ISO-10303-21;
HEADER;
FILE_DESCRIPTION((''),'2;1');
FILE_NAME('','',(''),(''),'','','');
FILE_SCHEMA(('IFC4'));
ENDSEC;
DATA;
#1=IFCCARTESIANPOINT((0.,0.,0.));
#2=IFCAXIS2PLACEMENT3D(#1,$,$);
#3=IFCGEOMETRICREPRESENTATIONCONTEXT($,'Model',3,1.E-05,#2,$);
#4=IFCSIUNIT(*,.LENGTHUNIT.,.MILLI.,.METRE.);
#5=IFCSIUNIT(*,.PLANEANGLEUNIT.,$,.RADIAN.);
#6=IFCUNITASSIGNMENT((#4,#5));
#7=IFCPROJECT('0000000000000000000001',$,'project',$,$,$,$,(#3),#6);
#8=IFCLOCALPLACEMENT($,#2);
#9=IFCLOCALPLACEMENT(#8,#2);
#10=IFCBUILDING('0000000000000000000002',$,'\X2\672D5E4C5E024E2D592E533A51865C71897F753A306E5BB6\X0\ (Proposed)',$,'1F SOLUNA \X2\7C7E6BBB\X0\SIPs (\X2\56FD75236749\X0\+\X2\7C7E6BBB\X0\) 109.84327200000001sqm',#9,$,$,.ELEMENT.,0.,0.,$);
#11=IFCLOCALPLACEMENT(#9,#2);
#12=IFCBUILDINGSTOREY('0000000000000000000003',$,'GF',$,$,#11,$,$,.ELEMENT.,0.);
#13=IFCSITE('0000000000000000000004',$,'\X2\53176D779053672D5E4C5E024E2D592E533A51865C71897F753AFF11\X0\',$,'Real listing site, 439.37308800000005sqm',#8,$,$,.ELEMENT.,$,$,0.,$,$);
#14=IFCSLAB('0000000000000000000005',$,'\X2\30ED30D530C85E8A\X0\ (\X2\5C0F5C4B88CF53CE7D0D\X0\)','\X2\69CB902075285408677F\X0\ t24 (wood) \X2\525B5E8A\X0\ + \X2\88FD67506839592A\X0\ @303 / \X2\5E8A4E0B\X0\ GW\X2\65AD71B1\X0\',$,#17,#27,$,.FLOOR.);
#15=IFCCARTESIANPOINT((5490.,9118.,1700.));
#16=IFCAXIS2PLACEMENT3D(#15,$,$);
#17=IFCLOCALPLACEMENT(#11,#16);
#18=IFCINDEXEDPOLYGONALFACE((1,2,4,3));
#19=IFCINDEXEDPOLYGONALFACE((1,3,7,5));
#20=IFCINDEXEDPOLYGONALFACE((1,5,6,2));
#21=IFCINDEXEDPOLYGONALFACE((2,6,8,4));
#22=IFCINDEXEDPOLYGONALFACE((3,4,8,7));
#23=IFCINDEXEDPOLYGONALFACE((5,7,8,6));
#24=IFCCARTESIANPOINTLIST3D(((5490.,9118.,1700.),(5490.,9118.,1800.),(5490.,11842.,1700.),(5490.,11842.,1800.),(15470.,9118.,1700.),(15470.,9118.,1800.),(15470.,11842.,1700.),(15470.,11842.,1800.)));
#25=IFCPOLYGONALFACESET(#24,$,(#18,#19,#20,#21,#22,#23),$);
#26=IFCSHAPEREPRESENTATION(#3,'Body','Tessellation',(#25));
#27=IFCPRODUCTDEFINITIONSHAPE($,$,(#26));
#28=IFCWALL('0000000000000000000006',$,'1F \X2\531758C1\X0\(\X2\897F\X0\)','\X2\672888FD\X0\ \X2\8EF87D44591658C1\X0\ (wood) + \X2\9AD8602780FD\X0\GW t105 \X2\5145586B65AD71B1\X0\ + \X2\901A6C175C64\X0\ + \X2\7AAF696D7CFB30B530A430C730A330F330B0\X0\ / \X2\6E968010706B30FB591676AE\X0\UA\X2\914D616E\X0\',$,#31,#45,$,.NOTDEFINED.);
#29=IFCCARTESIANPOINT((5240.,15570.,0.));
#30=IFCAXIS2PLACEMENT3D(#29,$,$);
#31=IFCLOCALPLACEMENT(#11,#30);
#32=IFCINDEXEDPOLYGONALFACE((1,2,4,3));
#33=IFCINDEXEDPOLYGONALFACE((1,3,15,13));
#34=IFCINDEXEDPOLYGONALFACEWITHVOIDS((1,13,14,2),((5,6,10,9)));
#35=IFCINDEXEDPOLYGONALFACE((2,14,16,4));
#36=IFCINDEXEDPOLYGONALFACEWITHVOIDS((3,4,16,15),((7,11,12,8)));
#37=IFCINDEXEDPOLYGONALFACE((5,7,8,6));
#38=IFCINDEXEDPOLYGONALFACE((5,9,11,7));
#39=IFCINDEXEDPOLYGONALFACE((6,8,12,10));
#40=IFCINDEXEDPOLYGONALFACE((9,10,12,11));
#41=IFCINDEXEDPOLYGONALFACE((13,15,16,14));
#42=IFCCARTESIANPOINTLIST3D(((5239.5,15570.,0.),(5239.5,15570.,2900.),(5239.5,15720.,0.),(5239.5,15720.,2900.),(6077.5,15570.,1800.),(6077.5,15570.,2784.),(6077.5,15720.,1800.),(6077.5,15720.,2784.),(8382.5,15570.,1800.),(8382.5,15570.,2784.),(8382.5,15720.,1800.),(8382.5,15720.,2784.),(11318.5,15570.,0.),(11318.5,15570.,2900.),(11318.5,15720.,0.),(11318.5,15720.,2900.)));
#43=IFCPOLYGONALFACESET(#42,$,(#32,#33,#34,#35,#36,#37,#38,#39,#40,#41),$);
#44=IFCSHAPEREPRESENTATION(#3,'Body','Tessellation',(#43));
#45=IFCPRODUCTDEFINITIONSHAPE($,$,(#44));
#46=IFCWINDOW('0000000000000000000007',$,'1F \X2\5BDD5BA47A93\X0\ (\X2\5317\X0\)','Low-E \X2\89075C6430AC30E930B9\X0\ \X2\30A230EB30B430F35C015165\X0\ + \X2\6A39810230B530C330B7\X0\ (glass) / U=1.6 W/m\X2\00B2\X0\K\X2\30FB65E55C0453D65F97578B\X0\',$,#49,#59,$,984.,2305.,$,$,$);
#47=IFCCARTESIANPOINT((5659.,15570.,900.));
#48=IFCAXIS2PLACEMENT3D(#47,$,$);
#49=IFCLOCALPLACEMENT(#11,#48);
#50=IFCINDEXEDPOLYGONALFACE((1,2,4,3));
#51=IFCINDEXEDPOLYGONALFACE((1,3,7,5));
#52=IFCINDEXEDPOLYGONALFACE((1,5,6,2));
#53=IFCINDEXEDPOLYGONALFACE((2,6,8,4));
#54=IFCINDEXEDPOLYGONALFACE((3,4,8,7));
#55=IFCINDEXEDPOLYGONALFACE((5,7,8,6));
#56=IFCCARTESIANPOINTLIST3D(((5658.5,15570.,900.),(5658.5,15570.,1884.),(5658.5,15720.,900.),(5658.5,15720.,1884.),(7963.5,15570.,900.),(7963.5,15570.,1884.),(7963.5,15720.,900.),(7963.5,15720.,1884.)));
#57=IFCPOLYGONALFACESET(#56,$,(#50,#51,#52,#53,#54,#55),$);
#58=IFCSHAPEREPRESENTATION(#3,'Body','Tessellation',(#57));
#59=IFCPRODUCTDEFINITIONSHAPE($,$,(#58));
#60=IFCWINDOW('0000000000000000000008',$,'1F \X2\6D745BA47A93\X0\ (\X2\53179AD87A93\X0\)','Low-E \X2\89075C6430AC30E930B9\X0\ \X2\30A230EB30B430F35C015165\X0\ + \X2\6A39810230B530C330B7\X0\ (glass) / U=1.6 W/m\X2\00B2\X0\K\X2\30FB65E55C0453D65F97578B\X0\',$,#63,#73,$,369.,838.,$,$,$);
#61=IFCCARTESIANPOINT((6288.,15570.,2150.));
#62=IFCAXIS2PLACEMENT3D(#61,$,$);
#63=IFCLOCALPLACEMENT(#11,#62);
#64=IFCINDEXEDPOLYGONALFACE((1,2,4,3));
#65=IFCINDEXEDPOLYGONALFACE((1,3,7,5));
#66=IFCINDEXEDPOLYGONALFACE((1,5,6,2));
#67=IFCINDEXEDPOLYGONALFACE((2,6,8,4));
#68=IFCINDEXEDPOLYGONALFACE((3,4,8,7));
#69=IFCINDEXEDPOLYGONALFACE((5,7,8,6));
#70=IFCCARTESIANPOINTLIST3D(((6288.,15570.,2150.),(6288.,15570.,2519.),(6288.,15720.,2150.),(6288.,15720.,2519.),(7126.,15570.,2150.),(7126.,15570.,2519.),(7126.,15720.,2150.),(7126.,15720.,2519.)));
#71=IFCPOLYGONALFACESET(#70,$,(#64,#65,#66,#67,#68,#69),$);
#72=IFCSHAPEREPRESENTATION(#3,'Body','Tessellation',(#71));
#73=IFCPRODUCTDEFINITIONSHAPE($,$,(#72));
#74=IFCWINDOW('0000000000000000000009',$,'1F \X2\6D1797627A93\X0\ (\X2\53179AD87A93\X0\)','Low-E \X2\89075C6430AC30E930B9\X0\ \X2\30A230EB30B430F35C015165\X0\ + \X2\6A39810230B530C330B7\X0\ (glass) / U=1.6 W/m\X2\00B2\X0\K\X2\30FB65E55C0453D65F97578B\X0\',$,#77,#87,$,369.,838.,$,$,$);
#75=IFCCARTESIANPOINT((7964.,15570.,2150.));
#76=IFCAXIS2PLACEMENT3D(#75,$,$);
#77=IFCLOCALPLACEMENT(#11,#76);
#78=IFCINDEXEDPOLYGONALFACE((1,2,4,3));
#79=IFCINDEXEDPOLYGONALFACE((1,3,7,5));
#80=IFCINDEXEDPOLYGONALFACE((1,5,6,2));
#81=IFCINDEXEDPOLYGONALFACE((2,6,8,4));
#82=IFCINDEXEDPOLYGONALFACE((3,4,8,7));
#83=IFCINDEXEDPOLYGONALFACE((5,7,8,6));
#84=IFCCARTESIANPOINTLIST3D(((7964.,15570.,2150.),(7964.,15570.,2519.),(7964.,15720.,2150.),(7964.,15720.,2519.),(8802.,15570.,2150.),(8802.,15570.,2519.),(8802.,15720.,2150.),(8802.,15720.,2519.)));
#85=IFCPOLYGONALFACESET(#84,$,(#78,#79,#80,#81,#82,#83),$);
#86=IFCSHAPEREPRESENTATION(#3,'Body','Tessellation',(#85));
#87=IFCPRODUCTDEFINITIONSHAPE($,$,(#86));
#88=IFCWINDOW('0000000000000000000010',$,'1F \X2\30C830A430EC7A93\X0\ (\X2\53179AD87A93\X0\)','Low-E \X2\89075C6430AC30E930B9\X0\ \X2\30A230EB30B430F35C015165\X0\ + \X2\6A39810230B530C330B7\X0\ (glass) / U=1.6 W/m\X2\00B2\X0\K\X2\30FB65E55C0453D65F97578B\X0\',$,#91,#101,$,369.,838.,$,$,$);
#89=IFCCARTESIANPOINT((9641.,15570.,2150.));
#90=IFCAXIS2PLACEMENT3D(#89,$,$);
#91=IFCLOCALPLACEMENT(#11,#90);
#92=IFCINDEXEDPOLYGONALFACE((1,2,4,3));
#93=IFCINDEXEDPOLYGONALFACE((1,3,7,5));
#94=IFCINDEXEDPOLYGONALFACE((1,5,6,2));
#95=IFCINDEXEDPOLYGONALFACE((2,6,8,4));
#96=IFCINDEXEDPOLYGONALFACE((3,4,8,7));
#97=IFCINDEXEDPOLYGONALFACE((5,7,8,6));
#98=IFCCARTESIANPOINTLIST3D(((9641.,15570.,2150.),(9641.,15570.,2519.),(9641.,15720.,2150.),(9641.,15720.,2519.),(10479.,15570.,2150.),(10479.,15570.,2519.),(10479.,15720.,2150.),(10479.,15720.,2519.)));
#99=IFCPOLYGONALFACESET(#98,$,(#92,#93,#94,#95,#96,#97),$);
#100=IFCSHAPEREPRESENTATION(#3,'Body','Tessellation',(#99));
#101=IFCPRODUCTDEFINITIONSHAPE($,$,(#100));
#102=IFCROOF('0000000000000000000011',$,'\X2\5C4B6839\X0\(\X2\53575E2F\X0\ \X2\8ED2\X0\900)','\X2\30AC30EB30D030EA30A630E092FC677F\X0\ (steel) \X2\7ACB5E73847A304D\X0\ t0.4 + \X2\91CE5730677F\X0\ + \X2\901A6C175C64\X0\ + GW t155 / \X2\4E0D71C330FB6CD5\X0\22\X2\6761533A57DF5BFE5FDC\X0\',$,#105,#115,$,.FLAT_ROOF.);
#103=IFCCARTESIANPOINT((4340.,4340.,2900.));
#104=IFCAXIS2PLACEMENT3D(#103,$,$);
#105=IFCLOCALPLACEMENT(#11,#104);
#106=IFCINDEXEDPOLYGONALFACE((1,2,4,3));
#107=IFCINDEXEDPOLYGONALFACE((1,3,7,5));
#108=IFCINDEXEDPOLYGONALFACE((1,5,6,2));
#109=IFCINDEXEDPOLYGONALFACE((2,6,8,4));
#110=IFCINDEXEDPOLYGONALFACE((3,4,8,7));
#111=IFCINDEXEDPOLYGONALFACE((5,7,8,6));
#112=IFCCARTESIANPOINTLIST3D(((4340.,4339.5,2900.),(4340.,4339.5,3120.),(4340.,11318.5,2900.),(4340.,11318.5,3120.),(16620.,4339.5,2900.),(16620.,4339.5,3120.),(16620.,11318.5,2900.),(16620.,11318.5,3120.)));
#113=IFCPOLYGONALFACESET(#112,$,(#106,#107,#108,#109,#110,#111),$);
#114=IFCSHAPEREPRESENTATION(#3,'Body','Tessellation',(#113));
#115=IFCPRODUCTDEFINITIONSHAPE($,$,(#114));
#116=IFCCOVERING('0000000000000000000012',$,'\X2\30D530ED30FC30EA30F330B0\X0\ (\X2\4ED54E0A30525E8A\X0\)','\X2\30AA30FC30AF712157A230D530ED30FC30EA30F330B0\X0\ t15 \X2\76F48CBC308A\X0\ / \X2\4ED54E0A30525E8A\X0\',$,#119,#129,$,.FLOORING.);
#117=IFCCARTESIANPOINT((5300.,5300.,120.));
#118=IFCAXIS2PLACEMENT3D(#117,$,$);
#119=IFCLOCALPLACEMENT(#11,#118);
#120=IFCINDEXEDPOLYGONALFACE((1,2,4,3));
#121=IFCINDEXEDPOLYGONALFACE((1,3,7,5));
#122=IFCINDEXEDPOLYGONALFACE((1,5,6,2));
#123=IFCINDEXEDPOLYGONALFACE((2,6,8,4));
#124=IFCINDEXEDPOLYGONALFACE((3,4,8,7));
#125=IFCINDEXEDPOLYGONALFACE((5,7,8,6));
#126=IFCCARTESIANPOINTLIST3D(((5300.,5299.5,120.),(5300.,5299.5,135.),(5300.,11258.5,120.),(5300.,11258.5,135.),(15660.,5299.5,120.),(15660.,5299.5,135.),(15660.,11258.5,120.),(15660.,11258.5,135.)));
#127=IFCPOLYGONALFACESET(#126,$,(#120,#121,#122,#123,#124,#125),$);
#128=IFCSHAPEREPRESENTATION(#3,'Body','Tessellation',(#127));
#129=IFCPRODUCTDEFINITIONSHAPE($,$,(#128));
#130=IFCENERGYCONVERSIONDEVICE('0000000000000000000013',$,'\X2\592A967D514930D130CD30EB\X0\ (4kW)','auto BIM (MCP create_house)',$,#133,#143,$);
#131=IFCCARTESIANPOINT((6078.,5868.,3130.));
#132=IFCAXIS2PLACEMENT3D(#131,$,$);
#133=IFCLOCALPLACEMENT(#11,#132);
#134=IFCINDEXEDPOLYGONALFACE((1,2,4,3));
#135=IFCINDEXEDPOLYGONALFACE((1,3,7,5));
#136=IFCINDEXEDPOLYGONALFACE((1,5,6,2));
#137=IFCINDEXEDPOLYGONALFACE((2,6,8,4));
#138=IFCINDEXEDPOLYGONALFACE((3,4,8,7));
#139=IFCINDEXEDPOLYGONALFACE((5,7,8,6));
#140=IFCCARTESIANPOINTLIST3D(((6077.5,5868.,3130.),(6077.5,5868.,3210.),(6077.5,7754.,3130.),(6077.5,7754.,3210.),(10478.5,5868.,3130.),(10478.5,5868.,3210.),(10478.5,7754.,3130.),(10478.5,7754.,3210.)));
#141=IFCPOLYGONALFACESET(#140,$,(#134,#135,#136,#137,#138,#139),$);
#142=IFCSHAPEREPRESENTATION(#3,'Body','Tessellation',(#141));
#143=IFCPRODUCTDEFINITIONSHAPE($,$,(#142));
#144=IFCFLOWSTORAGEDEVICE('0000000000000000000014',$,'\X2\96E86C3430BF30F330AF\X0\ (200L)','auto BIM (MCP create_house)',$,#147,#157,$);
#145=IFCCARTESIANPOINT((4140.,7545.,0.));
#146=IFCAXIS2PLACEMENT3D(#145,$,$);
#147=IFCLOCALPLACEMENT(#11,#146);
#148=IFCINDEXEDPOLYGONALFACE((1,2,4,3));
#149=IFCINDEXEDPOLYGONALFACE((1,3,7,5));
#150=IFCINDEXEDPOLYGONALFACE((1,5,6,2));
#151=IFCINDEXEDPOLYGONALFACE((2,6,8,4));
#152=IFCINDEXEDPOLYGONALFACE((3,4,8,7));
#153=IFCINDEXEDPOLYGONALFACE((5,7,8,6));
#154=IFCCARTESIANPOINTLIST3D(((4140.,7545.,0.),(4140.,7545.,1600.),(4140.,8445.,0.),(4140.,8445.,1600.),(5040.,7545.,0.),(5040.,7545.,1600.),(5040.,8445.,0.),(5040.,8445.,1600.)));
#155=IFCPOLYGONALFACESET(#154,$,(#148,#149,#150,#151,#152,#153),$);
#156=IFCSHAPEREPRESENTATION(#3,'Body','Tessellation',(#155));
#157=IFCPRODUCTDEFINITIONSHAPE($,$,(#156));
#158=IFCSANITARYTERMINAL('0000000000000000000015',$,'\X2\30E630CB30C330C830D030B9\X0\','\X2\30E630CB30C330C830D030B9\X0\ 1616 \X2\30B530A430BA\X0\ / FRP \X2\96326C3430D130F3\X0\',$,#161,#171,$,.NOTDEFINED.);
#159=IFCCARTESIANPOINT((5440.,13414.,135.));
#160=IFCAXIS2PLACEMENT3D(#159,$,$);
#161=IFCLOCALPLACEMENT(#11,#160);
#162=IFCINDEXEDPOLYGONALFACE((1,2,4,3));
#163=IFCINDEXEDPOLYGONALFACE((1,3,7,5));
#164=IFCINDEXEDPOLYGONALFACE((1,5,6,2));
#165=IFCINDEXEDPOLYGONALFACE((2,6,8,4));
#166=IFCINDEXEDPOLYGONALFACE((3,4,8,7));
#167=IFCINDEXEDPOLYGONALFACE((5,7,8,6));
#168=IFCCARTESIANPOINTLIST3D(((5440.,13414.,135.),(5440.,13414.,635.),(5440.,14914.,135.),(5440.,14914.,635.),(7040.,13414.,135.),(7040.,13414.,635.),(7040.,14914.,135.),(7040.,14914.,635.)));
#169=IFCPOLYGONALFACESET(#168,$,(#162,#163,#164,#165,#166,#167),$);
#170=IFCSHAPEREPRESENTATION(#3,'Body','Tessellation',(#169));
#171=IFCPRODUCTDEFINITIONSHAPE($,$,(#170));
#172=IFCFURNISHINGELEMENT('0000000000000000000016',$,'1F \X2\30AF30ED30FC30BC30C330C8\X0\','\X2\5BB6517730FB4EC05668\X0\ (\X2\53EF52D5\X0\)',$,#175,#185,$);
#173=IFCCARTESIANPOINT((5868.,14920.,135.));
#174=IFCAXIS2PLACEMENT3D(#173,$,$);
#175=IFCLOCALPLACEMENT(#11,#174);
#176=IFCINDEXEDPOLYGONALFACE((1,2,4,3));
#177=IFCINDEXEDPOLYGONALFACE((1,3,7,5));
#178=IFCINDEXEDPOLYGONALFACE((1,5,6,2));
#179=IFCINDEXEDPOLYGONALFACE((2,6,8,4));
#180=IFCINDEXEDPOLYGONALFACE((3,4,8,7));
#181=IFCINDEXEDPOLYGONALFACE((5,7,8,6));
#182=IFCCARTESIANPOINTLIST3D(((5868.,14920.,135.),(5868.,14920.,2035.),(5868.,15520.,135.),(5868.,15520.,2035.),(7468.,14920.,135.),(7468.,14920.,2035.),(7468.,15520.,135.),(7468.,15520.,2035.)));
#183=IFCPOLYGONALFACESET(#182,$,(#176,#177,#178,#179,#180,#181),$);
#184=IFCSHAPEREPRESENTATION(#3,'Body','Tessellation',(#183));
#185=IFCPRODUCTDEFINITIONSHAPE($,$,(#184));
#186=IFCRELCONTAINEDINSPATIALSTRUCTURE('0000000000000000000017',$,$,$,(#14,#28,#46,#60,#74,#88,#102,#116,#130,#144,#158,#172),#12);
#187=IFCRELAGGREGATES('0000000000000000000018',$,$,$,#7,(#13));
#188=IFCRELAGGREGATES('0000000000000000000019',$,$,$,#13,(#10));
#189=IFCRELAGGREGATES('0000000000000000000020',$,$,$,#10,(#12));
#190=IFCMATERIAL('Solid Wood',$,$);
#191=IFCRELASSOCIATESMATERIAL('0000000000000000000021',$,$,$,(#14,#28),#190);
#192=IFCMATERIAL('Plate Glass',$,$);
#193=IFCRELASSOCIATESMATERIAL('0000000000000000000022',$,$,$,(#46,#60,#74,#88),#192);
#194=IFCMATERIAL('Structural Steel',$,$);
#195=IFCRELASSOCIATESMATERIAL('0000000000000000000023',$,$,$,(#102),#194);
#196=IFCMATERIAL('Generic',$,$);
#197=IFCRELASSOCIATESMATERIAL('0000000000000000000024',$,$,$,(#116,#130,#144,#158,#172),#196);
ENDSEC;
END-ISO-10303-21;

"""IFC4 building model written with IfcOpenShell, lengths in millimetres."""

from ifc_helpers import new_model, si_unit, frame, frame_2d, origin, place, context, project, spatial, rectangle, extrude, material, element, fill, save


model = new_model("IFC4")

# Units and contexts
model_context = context("Model", 3, precision=1e-05, world=origin())
ifc_project = project(units=[si_unit("LENGTHUNIT", "METRE", prefix="MILLI"), si_unit("PLANEANGLEUNIT", "RADIAN")], contexts=[model_context])

# Site, building, storey
site_placement = place(None, origin())
site = spatial("IfcSite", under=ifc_project, at=site_placement, Name="北海道札幌市中央区円山西町１", ObjectType="Real listing site, 439.37308800000005sqm", CompositionType="ELEMENT", RefElevation=0.0)
building_placement = place(site_placement, origin())
building = spatial("IfcBuilding", under=site, at=building_placement, Name="札幌市中央区円山西町の家 (Proposed)", ObjectType="1F SOLUNA 籾殻SIPs (国産杉+籾殻) 109.84327200000001sqm", CompositionType="ELEMENT", ElevationOfRefHeight=0.0, ElevationOfTerrain=0.0)
storey_placement = place(building_placement, origin())
storey = spatial("IfcBuildingStorey", under=building, at=storey_placement, Name="GF", CompositionType="ELEMENT", Elevation=0.0)

# Slab
ifc_material_1 = material(Name="Solid Wood")
slab_1_placement = place(storey_placement, frame((5490.0, 9118.0, 1700.0)))
element("IfcSlab", 1, at=slab_1_placement, inside=storey, material=ifc_material_1, Name="ロフト床 (小屋裏収納)", Description="構造用合板 t24 (wood) 剛床 + 製材根太 @303 / 床下 GW断熱", PredefinedType="FLOOR", context=model_context, shape_type="SweptSolid", body=[
    extrude(rectangle(XDim=9980.0, YDim=2724.0, at=frame_2d((4990.0, 1362.0))), frame((5490.0, 9118.0, 1700.0)), (0.0, 0.0, 1.0), 100.0),
])

# Shared definitions
ifc_material_2 = material(Name="Plate Glass")

# Wall, openings, windows
wall_1_placement = place(storey_placement, frame((5240.0, 15570.0, 0.0)))
wall_1 = element("IfcWall", 2, at=wall_1_placement, inside=storey, material=ifc_material_1, Name="1F 北壁(西)", Description="木製 軸組外壁 (wood) + 高性能GW t105 充填断熱 + 通気層 + 窯業系サイディング / 準耐火・外皮UA配慮", PredefinedType="NOTDEFINED", context=model_context, shape_type="SweptSolid", body=[
    extrude(rectangle(XDim=6079.0, YDim=150.0, at=frame_2d((3039.0, 75.0))), frame((5240.0, 15570.0, 0.0)), (0.0, 0.0, 1.0), 2900.0),
])
opening_1_placement = place(storey_placement, frame((5659.0, 15570.0, 900.0)))
opening_1 = element("IfcOpeningElement", 3, at=opening_1_placement, cuts=wall_1, PredefinedType="NOTDEFINED", context=model_context, shape_type="SweptSolid", body=[
    extrude(rectangle(XDim=2305.0, YDim=150.0, at=frame_2d((1152.0, 75.0))), frame((5659.0, 15570.0, 900.0)), (0.0, 0.0, 1.0), 984.0),
])
opening_2_placement = place(storey_placement, frame((6288.0, 15570.0, 2150.0)))
opening_2 = element("IfcOpeningElement", 4, at=opening_2_placement, cuts=wall_1, PredefinedType="NOTDEFINED", context=model_context, shape_type="SweptSolid", body=[
    extrude(rectangle(XDim=838.0, YDim=150.0, at=frame_2d((419.0, 75.0))), frame((6288.0, 15570.0, 2150.0)), (0.0, 0.0, 1.0), 369.0),
])
opening_3_placement = place(storey_placement, frame((7964.0, 15570.0, 2150.0)))
opening_3 = element("IfcOpeningElement", 5, at=opening_3_placement, cuts=wall_1, PredefinedType="NOTDEFINED", context=model_context, shape_type="SweptSolid", body=[
    extrude(rectangle(XDim=838.0, YDim=150.0, at=frame_2d((419.0, 75.0))), frame((7964.0, 15570.0, 2150.0)), (0.0, 0.0, 1.0), 369.0),
])
opening_4_placement = place(storey_placement, frame((9641.0, 15570.0, 2150.0)))
opening_4 = element("IfcOpeningElement", 6, at=opening_4_placement, cuts=wall_1, PredefinedType="NOTDEFINED", context=model_context, shape_type="SweptSolid", body=[
    extrude(rectangle(XDim=838.0, YDim=150.0, at=frame_2d((419.0, 75.0))), frame((9641.0, 15570.0, 2150.0)), (0.0, 0.0, 1.0), 369.0),
])
window_1_placement = place(storey_placement, frame((5659.0, 15570.0, 900.0)))
window_1 = element("IfcWindow", 7, at=window_1_placement, inside=storey, material=ifc_material_2, Name="1F 寝室窓 (北)", Description="Low-E 複層ガラス アルゴン封入 + 樹脂サッシ (glass) / U=1.6 W/m²K・日射取得型", OverallHeight=984.0, OverallWidth=2305.0, context=model_context, shape_type="SweptSolid", body=[
    extrude(rectangle(XDim=2305.0, YDim=150.0, at=frame_2d((1152.0, 75.0))), frame((5659.0, 15570.0, 900.0)), (0.0, 0.0, 1.0), 984.0),
])
fill(opening_1, window_1)
window_2_placement = place(storey_placement, frame((6288.0, 15570.0, 2150.0)))
window_2 = element("IfcWindow", 8, at=window_2_placement, inside=storey, material=ifc_material_2, Name="1F 浴室窓 (北高窓)", Description="Low-E 複層ガラス アルゴン封入 + 樹脂サッシ (glass) / U=1.6 W/m²K・日射取得型", OverallHeight=369.0, OverallWidth=838.0, context=model_context, shape_type="SweptSolid", body=[
    extrude(rectangle(XDim=838.0, YDim=150.0, at=frame_2d((419.0, 75.0))), frame((6288.0, 15570.0, 2150.0)), (0.0, 0.0, 1.0), 369.0),
])
fill(opening_2, window_2)
window_3_placement = place(storey_placement, frame((7964.0, 15570.0, 2150.0)))
window_3 = element("IfcWindow", 9, at=window_3_placement, inside=storey, material=ifc_material_2, Name="1F 洗面窓 (北高窓)", Description="Low-E 複層ガラス アルゴン封入 + 樹脂サッシ (glass) / U=1.6 W/m²K・日射取得型", OverallHeight=369.0, OverallWidth=838.0, context=model_context, shape_type="SweptSolid", body=[
    extrude(rectangle(XDim=838.0, YDim=150.0, at=frame_2d((419.0, 75.0))), frame((7964.0, 15570.0, 2150.0)), (0.0, 0.0, 1.0), 369.0),
])
fill(opening_3, window_3)
window_4_placement = place(storey_placement, frame((9641.0, 15570.0, 2150.0)))
window_4 = element("IfcWindow", 10, at=window_4_placement, inside=storey, material=ifc_material_2, Name="1F トイレ窓 (北高窓)", Description="Low-E 複層ガラス アルゴン封入 + 樹脂サッシ (glass) / U=1.6 W/m²K・日射取得型", OverallHeight=369.0, OverallWidth=838.0, context=model_context, shape_type="SweptSolid", body=[
    extrude(rectangle(XDim=838.0, YDim=150.0, at=frame_2d((419.0, 75.0))), frame((9641.0, 15570.0, 2150.0)), (0.0, 0.0, 1.0), 369.0),
])
fill(opening_4, window_4)

# Roof
ifc_material_3 = material(Name="Structural Steel")
roof_1_placement = place(storey_placement, frame((4340.0, 4340.0, 2900.0)))
element("IfcRoof", 11, at=roof_1_placement, inside=storey, material=ifc_material_3, Name="屋根(南帯 軒900)", Description="ガルバリウム鋼板 (steel) 立平葺き t0.4 + 野地板 + 通気層 + GW t155 / 不燃・法22条区域対応", PredefinedType="FLAT_ROOF", context=model_context, shape_type="SweptSolid", body=[
    extrude(rectangle(XDim=12280.0, YDim=6979.0, at=frame_2d((6140.0, 3489.0))), frame((4340.0, 4340.0, 2900.0)), (0.0, 0.0, 1.0), 220.0),
])

# Covering
ifc_material_4 = material(Name="Generic")
covering_1_placement = place(storey_placement, frame((5300.0, 5300.0, 120.0)))
element("IfcCovering", 12, at=covering_1_placement, inside=storey, material=ifc_material_4, Name="フローリング (仕上げ床)", Description="オーク無垢フローリング t15 直貼り / 仕上げ床", PredefinedType="FLOORING", context=model_context, shape_type="SweptSolid", body=[
    extrude(rectangle(XDim=10360.0, YDim=5959.0, at=frame_2d((5180.0, 2979.0))), frame((5300.0, 5300.0, 120.0)), (0.0, 0.0, 1.0), 15.0),
])

# Energy conversion device
energy_conversion_device_placement = place(storey_placement, frame((6078.0, 5868.0, 3130.0)))
element("IfcEnergyConversionDevice", 13, at=energy_conversion_device_placement, inside=storey, material=ifc_material_4, Name="太陽光パネル (4kW)", Description="auto BIM (MCP create_house)", context=model_context, shape_type="SweptSolid", body=[
    extrude(rectangle(XDim=4401.0, YDim=1886.0, at=frame_2d((2200.0, 943.0))), frame((6078.0, 5868.0, 3130.0)), (0.0, 0.0, 1.0), 80.0),
])

# Flow storage device
flow_storage_device_placement = place(storey_placement, frame((4140.0, 7545.0, 0.0)))
element("IfcFlowStorageDevice", 14, at=flow_storage_device_placement, inside=storey, material=ifc_material_4, Name="雨水タンク (200L)", Description="auto BIM (MCP create_house)", context=model_context, shape_type="SweptSolid", body=[
    extrude(rectangle(XDim=900.0, YDim=900.0, at=frame_2d((450.0, 450.0))), frame((4140.0, 7545.0, 0.0)), (0.0, 0.0, 1.0), 1600.0),
])

# Sanitary terminal
sanitary_terminal_placement = place(storey_placement, frame((5440.0, 13414.0, 135.0)))
element("IfcSanitaryTerminal", 15, at=sanitary_terminal_placement, inside=storey, material=ifc_material_4, Name="ユニットバス", Description="ユニットバス 1616 サイズ / FRP 防水パン", PredefinedType="NOTDEFINED", context=model_context, shape_type="SweptSolid", body=[
    extrude(rectangle(XDim=1600.0, YDim=1500.0, at=frame_2d((800.0, 750.0))), frame((5440.0, 13414.0, 135.0)), (0.0, 0.0, 1.0), 500.0),
])

# Furnishing element
furnishing_1_placement = place(storey_placement, frame((5868.0, 14920.0, 135.0)))
element("IfcFurnishingElement", 16, at=furnishing_1_placement, inside=storey, material=ifc_material_4, Name="1F クローゼット", Description="家具・什器 (可動)", context=model_context, shape_type="SweptSolid", body=[
    extrude(rectangle(XDim=1600.0, YDim=600.0, at=frame_2d((800.0, 300.0))), frame((5868.0, 14920.0, 135.0)), (0.0, 0.0, 1.0), 1900.0),
])

save(model, "model.ifc")
